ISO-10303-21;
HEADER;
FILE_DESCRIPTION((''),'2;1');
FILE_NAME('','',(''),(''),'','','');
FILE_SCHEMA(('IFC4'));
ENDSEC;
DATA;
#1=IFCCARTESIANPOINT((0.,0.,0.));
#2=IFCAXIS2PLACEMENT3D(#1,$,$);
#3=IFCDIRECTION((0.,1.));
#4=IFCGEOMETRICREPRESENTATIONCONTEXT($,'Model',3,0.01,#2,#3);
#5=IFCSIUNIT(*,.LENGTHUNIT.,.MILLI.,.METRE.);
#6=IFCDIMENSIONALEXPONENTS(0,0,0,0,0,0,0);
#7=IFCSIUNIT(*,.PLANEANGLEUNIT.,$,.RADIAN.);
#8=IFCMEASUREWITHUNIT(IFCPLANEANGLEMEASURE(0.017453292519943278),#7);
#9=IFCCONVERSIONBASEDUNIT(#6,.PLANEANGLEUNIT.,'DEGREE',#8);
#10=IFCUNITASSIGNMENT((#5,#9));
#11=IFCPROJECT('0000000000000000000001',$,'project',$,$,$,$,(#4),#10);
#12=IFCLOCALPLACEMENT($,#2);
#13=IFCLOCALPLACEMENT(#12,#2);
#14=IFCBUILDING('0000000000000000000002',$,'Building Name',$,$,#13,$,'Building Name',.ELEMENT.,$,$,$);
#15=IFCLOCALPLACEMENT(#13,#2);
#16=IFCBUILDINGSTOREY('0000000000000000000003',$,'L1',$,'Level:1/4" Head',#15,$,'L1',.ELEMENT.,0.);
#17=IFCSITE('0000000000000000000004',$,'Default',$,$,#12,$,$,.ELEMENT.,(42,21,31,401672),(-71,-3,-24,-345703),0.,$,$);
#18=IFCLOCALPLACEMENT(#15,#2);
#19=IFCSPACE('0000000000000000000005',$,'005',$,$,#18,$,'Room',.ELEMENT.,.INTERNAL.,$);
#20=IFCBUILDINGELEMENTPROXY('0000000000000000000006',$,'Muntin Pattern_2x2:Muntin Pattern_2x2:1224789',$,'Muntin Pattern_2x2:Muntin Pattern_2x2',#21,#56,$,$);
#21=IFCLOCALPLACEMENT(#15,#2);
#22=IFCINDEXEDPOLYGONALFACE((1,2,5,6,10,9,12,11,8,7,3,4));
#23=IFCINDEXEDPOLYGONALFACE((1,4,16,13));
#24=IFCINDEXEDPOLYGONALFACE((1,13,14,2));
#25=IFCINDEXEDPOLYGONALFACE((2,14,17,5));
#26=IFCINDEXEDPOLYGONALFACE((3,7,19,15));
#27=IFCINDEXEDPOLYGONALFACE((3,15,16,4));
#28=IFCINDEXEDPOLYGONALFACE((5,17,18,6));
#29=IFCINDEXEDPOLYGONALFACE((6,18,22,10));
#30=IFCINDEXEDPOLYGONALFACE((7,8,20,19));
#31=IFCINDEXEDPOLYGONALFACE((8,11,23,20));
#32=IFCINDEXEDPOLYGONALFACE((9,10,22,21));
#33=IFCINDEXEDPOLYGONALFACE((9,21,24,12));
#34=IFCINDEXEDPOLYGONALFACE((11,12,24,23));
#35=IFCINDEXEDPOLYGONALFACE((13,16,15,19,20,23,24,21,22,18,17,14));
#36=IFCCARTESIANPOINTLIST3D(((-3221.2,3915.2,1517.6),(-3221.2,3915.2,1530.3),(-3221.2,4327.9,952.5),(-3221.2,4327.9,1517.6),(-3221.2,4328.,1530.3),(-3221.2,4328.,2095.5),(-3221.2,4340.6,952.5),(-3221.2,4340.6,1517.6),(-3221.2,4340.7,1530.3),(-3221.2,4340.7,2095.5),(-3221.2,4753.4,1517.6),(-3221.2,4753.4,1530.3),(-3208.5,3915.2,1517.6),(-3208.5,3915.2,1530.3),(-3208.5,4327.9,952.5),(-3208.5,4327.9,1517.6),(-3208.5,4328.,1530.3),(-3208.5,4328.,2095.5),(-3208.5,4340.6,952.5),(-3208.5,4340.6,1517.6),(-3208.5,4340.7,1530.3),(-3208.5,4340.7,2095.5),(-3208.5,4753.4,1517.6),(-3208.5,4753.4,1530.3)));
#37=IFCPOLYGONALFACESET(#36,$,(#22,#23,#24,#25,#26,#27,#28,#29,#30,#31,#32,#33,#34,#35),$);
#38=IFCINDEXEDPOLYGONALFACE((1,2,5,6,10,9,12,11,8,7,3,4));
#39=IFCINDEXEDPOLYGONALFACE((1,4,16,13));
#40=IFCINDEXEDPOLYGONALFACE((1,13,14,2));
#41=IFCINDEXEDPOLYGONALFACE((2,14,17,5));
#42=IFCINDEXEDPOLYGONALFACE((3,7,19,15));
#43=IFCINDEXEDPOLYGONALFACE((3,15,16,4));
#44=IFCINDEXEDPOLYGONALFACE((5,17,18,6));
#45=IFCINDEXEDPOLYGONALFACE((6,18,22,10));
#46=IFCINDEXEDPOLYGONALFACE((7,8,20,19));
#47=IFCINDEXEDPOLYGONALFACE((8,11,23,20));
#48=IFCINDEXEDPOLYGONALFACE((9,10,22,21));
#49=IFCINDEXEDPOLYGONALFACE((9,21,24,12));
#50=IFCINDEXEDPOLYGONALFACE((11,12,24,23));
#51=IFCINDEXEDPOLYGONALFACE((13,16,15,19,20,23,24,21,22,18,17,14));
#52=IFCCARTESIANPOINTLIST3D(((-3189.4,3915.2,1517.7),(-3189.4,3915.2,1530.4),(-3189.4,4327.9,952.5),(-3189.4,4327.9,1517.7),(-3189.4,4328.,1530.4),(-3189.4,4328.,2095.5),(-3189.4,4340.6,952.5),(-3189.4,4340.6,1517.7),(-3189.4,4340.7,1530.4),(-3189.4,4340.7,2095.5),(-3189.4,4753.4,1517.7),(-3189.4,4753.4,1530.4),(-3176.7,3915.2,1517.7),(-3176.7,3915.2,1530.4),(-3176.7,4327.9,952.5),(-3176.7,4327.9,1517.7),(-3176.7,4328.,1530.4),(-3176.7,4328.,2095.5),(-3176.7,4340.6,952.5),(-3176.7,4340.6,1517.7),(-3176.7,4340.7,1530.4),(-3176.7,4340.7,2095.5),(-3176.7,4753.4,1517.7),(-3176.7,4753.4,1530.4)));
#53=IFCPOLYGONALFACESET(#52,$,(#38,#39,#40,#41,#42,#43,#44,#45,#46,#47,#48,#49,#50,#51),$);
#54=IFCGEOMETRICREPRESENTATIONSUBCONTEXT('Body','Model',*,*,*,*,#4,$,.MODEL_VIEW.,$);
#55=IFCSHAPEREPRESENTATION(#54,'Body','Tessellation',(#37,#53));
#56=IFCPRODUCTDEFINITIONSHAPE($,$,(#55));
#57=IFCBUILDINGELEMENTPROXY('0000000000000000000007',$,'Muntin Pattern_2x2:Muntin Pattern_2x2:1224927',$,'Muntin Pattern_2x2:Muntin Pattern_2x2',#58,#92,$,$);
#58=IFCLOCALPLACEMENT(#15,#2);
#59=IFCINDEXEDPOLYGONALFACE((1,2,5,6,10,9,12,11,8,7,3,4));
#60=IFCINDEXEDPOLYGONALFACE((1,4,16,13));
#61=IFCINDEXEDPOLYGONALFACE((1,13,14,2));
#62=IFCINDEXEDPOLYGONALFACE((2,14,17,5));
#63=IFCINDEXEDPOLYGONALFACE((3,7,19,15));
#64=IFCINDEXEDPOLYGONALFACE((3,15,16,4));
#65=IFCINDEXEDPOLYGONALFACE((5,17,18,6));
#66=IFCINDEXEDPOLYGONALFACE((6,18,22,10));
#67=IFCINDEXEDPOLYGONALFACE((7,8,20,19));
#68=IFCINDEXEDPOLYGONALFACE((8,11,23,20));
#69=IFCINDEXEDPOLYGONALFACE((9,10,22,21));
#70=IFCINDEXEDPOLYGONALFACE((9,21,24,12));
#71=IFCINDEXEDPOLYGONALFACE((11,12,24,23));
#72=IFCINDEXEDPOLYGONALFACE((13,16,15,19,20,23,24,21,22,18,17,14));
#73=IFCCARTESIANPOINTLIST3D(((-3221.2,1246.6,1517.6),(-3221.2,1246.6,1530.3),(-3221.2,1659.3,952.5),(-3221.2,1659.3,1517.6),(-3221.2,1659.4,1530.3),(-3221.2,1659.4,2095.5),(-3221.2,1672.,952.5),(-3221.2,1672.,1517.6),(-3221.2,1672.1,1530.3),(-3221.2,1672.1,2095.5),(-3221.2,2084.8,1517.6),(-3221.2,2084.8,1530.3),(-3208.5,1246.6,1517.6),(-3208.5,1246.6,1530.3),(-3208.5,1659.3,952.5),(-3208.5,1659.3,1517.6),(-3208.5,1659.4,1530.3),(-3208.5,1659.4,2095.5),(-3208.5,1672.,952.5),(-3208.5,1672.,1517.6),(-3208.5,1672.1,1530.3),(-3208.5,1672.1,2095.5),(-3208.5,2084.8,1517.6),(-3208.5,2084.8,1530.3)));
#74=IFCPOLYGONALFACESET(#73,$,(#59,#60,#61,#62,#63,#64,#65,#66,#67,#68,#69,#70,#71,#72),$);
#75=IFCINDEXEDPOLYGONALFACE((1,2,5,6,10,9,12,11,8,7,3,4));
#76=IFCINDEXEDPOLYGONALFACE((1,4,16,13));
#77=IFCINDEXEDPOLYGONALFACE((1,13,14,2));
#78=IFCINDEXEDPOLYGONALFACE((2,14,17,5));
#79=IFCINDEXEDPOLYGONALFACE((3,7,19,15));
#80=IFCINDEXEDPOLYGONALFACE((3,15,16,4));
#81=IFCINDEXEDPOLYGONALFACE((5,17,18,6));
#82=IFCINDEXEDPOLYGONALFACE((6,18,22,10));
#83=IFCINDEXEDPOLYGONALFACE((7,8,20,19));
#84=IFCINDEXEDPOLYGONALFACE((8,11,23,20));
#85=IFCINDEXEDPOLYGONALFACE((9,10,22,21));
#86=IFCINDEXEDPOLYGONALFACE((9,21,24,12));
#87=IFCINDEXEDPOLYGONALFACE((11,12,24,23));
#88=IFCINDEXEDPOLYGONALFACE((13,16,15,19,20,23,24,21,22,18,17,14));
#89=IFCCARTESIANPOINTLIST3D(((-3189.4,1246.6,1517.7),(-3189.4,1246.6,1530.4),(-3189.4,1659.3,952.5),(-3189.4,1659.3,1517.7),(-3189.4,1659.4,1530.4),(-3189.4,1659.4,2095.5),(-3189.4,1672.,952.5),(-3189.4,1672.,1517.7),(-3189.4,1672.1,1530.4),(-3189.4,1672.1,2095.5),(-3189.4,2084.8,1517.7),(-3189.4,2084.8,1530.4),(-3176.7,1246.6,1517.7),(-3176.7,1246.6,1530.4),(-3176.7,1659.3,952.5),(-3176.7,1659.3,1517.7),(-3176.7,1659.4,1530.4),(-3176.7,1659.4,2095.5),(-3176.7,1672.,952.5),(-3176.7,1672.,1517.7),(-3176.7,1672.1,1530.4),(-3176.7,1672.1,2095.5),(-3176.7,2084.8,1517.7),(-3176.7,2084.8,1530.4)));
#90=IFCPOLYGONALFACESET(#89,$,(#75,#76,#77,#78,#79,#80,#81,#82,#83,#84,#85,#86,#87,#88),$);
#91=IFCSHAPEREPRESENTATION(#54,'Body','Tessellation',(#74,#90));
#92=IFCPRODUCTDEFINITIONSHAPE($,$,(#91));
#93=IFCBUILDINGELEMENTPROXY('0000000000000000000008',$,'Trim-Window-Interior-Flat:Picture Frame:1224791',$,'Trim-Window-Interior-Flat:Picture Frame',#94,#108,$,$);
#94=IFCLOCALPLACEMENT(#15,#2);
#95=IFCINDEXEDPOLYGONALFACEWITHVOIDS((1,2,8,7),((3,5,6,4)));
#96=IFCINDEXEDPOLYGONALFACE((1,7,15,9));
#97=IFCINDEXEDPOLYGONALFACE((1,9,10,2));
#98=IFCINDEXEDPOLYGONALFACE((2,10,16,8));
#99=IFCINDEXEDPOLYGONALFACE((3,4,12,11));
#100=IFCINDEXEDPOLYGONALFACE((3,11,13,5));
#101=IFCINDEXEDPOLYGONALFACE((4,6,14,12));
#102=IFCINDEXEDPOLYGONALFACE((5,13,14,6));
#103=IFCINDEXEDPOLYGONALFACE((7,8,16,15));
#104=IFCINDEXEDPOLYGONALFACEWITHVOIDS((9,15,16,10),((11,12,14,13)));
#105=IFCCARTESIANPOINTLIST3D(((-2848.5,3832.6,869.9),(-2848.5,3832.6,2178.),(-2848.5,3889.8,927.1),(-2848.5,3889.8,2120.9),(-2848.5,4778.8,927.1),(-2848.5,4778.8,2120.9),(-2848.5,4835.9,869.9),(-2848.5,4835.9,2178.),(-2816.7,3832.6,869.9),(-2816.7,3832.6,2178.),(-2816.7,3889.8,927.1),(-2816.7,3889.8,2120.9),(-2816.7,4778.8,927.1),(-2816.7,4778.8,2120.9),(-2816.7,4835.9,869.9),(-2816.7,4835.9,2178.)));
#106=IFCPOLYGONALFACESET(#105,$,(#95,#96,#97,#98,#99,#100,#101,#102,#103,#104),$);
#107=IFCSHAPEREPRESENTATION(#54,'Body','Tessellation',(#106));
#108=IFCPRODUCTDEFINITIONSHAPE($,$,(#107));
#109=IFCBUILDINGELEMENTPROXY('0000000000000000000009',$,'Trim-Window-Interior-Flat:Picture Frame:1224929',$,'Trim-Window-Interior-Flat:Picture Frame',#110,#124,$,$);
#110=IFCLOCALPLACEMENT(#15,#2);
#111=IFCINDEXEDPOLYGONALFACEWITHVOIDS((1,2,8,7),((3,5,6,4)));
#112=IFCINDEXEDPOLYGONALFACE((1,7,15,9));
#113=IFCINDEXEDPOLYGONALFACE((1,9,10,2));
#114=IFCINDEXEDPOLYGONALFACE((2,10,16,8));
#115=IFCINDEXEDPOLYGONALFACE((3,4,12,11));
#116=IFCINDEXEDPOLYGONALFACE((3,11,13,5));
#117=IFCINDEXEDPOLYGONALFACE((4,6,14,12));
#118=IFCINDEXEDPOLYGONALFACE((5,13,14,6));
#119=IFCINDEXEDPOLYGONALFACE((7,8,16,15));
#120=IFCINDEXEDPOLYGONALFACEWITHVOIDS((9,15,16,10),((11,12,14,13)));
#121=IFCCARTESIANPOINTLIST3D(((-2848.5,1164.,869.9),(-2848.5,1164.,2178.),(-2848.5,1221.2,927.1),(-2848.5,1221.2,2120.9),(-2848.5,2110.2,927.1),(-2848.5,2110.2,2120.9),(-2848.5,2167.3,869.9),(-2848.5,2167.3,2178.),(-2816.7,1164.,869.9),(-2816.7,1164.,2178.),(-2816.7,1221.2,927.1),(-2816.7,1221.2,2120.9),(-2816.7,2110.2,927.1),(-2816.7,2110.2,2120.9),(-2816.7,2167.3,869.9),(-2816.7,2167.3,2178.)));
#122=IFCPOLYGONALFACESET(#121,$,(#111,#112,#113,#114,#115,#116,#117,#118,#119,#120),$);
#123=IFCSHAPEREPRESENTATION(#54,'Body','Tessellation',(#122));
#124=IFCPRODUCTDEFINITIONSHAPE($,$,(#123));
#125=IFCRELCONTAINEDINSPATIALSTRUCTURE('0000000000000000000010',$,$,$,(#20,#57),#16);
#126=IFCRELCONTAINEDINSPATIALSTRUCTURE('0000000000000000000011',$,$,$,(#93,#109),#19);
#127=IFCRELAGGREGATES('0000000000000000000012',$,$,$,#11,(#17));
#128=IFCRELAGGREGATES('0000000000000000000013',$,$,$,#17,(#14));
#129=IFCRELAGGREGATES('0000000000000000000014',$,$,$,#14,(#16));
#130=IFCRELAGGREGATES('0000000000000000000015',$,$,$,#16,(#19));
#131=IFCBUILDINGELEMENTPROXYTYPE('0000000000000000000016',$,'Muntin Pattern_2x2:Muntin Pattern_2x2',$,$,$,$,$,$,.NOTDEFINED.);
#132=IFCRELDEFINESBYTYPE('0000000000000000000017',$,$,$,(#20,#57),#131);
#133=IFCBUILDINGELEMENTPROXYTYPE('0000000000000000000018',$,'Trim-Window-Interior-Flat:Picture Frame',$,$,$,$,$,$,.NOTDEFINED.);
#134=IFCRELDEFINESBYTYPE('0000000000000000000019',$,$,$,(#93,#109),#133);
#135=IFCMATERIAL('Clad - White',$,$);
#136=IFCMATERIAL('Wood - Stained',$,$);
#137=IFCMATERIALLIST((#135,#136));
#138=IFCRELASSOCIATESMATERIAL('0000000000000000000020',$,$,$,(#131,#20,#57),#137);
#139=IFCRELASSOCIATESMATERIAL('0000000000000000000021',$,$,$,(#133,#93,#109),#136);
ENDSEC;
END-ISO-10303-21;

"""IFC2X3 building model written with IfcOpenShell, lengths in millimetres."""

from ifc_helpers import new_model, entity, si_unit, converted_unit, direction, frame, origin, place, context, subcontext, project, spatial, polyline, outline, extrude, source, transform, mapped, material, material_list, type_object, type_shapes, element, save


model = new_model("IFC2X3")

# Units and contexts
model_context = context("Model", 3, precision=0.01, world=origin(), true_north=direction((0.0, 1.0)))
body_context = subcontext(model_context, "Body", "Model", "MODEL_VIEW")
ifc_project = project(units=[si_unit("LENGTHUNIT", "METRE", prefix="MILLI"), converted_unit("PLANEANGLEUNIT", "DEGREE", entity("IfcPlaneAngleMeasure", 0.017453292519943278), si_unit("PLANEANGLEUNIT", "RADIAN"), dimensions=[0, 0, 0, 0, 0, 0, 0])], contexts=[model_context])

# Site, building, storey
site_placement = place(None, origin())
site = spatial("IfcSite", under=ifc_project, at=site_placement, Name="Default", CompositionType="ELEMENT", RefLatitude=(42, 21, 31, 401672), RefLongitude=(-71, -3, -24, -345703), RefElevation=0.0)
building_placement = place(site_placement, origin())
building = spatial("IfcBuilding", under=site, at=building_placement, Name="Building Name", LongName="Building Name", CompositionType="ELEMENT")
storey_placement = place(building_placement, origin())
storey = spatial("IfcBuildingStorey", under=building, at=storey_placement, Name="L1", ObjectType="Level:1/4\" Head", LongName="L1", CompositionType="ELEMENT", Elevation=0.0)

# Building element proxies
ifc_material_1 = material(Name="Clad - White")
ifc_material_2 = material(Name="Wood - Stained")
ifc_material_list = material_list([ifc_material_1, ifc_material_2])
building_element_proxy_type_1 = type_object("IfcBuildingElementProxyType", Name="Muntin Pattern_2x2:Muntin Pattern_2x2", PredefinedType="NOTDEFINED", material=ifc_material_list)
shared_shape_1 = source(origin(), body_context, "Body", "SweptSolid", [
    extrude(outline(polyline([(6.4, -6.4), (571.5, -6.4), (571.5, 6.3), (6.4, 6.3), (6.4, 419.1), (-6.3, 419.1), (-6.3, 6.3), (-571.5, 6.3), (-571.5, -6.4), (-6.3, -6.4), (-6.3, -419.1), (6.4, -419.1), (6.4, -6.4)])), frame((0.0, -22.2, 571.5), z_axis=(0.0, 1.0, 0.0), x_axis=(0.0, 0.0, 1.0)), (0.0, 0.0, 1.0), 12.7),
    extrude(outline(polyline([(6.4, -6.4), (571.5, -6.4), (571.5, 6.3), (6.4, 6.3), (6.4, 419.1), (-6.3, 419.1), (-6.3, 6.3), (-571.5, 6.3), (-571.5, -6.4), (-6.3, -6.4), (-6.3, -419.1), (6.4, -419.1), (6.4, -6.4)])), frame((0.0, 9.5, 571.5), z_axis=(0.0, 1.0, 0.0), x_axis=(0.0, 0.0, 1.0)), (0.0, 0.0, 1.0), 12.7),
])
type_shapes(building_element_proxy_type_1, [shared_shape_1])
for number, where, z_axis, x_axis, name in (
    (1, (-3199.0, 4334.3, 952.5), (0.0, 0.0, 1.0), (0.0, -1.0, 0.0), "Muntin Pattern_2x2:Muntin Pattern_2x2:1224789"),
    (2, (-3199.0, 1665.7, 952.5), (0.0, 0.0, 1.0), (0.0, -1.0, 0.0), "Muntin Pattern_2x2:Muntin Pattern_2x2:1224927"),
):
    element("IfcBuildingElementProxy", number, at=place(storey_placement, frame(where, z_axis=z_axis, x_axis=x_axis)), inside=storey, type_object=building_element_proxy_type_1, material=ifc_material_list, Name=name, ObjectType="Muntin Pattern_2x2:Muntin Pattern_2x2", context=body_context, shape_type="MappedRepresentation", body=[
        mapped(shared_shape_1, transform((0.0, 0.0, 0.0), scale=1.0)),
    ])

# Shared definitions
space_placement = place(storey_placement, origin())
space = spatial("IfcSpace", under=storey, at=space_placement, Name="005", LongName="Room", CompositionType="ELEMENT", InteriorOrExteriorSpace="INTERNAL")

# Building element proxies
building_element_proxy_type_2 = type_object("IfcBuildingElementProxyType", Name="Trim-Window-Interior-Flat:Picture Frame", PredefinedType="NOTDEFINED", material=ifc_material_2)
shared_shape_2 = source(origin(), body_context, "Body", "SweptSolid", [
    extrude(outline(polyline([(-501.6, -654.0), (501.6, -654.0), (501.6, 654.0), (-501.6, 654.0), (-501.6, -654.0)]), holes=[polyline([(-444.5, -596.9), (-444.5, 596.9), (444.5, 596.9), (444.5, -596.9), (-444.5, -596.9)])]), frame((0.0, -609.6, 0.0), z_axis=(0.0, 0.0, 1.0), x_axis=(-1.0, 0.0, 0.0)), (0.0, 0.0, 1.0), 31.7),
])
type_shapes(building_element_proxy_type_2, [shared_shape_2])
for number, where, z_axis, x_axis, name in (
    (3, (-2848.5, 4334.3, 2133.6), (1.0, 0.0, 0.0), (0.0, 1.0, 0.0), "Trim-Window-Interior-Flat:Picture Frame:1224791"),
    (4, (-2848.5, 1665.7, 2133.6), (1.0, 0.0, 0.0), (0.0, 1.0, 0.0), "Trim-Window-Interior-Flat:Picture Frame:1224929"),
):
    element("IfcBuildingElementProxy", number, at=place(space_placement, frame(where, z_axis=z_axis, x_axis=x_axis)), inside=space, type_object=building_element_proxy_type_2, material=ifc_material_2, Name=name, ObjectType="Trim-Window-Interior-Flat:Picture Frame", context=body_context, shape_type="MappedRepresentation", body=[
        mapped(shared_shape_2, transform((0.0, 0.0, 0.0), scale=1.0)),
    ])

save(model, "model.ifc")
